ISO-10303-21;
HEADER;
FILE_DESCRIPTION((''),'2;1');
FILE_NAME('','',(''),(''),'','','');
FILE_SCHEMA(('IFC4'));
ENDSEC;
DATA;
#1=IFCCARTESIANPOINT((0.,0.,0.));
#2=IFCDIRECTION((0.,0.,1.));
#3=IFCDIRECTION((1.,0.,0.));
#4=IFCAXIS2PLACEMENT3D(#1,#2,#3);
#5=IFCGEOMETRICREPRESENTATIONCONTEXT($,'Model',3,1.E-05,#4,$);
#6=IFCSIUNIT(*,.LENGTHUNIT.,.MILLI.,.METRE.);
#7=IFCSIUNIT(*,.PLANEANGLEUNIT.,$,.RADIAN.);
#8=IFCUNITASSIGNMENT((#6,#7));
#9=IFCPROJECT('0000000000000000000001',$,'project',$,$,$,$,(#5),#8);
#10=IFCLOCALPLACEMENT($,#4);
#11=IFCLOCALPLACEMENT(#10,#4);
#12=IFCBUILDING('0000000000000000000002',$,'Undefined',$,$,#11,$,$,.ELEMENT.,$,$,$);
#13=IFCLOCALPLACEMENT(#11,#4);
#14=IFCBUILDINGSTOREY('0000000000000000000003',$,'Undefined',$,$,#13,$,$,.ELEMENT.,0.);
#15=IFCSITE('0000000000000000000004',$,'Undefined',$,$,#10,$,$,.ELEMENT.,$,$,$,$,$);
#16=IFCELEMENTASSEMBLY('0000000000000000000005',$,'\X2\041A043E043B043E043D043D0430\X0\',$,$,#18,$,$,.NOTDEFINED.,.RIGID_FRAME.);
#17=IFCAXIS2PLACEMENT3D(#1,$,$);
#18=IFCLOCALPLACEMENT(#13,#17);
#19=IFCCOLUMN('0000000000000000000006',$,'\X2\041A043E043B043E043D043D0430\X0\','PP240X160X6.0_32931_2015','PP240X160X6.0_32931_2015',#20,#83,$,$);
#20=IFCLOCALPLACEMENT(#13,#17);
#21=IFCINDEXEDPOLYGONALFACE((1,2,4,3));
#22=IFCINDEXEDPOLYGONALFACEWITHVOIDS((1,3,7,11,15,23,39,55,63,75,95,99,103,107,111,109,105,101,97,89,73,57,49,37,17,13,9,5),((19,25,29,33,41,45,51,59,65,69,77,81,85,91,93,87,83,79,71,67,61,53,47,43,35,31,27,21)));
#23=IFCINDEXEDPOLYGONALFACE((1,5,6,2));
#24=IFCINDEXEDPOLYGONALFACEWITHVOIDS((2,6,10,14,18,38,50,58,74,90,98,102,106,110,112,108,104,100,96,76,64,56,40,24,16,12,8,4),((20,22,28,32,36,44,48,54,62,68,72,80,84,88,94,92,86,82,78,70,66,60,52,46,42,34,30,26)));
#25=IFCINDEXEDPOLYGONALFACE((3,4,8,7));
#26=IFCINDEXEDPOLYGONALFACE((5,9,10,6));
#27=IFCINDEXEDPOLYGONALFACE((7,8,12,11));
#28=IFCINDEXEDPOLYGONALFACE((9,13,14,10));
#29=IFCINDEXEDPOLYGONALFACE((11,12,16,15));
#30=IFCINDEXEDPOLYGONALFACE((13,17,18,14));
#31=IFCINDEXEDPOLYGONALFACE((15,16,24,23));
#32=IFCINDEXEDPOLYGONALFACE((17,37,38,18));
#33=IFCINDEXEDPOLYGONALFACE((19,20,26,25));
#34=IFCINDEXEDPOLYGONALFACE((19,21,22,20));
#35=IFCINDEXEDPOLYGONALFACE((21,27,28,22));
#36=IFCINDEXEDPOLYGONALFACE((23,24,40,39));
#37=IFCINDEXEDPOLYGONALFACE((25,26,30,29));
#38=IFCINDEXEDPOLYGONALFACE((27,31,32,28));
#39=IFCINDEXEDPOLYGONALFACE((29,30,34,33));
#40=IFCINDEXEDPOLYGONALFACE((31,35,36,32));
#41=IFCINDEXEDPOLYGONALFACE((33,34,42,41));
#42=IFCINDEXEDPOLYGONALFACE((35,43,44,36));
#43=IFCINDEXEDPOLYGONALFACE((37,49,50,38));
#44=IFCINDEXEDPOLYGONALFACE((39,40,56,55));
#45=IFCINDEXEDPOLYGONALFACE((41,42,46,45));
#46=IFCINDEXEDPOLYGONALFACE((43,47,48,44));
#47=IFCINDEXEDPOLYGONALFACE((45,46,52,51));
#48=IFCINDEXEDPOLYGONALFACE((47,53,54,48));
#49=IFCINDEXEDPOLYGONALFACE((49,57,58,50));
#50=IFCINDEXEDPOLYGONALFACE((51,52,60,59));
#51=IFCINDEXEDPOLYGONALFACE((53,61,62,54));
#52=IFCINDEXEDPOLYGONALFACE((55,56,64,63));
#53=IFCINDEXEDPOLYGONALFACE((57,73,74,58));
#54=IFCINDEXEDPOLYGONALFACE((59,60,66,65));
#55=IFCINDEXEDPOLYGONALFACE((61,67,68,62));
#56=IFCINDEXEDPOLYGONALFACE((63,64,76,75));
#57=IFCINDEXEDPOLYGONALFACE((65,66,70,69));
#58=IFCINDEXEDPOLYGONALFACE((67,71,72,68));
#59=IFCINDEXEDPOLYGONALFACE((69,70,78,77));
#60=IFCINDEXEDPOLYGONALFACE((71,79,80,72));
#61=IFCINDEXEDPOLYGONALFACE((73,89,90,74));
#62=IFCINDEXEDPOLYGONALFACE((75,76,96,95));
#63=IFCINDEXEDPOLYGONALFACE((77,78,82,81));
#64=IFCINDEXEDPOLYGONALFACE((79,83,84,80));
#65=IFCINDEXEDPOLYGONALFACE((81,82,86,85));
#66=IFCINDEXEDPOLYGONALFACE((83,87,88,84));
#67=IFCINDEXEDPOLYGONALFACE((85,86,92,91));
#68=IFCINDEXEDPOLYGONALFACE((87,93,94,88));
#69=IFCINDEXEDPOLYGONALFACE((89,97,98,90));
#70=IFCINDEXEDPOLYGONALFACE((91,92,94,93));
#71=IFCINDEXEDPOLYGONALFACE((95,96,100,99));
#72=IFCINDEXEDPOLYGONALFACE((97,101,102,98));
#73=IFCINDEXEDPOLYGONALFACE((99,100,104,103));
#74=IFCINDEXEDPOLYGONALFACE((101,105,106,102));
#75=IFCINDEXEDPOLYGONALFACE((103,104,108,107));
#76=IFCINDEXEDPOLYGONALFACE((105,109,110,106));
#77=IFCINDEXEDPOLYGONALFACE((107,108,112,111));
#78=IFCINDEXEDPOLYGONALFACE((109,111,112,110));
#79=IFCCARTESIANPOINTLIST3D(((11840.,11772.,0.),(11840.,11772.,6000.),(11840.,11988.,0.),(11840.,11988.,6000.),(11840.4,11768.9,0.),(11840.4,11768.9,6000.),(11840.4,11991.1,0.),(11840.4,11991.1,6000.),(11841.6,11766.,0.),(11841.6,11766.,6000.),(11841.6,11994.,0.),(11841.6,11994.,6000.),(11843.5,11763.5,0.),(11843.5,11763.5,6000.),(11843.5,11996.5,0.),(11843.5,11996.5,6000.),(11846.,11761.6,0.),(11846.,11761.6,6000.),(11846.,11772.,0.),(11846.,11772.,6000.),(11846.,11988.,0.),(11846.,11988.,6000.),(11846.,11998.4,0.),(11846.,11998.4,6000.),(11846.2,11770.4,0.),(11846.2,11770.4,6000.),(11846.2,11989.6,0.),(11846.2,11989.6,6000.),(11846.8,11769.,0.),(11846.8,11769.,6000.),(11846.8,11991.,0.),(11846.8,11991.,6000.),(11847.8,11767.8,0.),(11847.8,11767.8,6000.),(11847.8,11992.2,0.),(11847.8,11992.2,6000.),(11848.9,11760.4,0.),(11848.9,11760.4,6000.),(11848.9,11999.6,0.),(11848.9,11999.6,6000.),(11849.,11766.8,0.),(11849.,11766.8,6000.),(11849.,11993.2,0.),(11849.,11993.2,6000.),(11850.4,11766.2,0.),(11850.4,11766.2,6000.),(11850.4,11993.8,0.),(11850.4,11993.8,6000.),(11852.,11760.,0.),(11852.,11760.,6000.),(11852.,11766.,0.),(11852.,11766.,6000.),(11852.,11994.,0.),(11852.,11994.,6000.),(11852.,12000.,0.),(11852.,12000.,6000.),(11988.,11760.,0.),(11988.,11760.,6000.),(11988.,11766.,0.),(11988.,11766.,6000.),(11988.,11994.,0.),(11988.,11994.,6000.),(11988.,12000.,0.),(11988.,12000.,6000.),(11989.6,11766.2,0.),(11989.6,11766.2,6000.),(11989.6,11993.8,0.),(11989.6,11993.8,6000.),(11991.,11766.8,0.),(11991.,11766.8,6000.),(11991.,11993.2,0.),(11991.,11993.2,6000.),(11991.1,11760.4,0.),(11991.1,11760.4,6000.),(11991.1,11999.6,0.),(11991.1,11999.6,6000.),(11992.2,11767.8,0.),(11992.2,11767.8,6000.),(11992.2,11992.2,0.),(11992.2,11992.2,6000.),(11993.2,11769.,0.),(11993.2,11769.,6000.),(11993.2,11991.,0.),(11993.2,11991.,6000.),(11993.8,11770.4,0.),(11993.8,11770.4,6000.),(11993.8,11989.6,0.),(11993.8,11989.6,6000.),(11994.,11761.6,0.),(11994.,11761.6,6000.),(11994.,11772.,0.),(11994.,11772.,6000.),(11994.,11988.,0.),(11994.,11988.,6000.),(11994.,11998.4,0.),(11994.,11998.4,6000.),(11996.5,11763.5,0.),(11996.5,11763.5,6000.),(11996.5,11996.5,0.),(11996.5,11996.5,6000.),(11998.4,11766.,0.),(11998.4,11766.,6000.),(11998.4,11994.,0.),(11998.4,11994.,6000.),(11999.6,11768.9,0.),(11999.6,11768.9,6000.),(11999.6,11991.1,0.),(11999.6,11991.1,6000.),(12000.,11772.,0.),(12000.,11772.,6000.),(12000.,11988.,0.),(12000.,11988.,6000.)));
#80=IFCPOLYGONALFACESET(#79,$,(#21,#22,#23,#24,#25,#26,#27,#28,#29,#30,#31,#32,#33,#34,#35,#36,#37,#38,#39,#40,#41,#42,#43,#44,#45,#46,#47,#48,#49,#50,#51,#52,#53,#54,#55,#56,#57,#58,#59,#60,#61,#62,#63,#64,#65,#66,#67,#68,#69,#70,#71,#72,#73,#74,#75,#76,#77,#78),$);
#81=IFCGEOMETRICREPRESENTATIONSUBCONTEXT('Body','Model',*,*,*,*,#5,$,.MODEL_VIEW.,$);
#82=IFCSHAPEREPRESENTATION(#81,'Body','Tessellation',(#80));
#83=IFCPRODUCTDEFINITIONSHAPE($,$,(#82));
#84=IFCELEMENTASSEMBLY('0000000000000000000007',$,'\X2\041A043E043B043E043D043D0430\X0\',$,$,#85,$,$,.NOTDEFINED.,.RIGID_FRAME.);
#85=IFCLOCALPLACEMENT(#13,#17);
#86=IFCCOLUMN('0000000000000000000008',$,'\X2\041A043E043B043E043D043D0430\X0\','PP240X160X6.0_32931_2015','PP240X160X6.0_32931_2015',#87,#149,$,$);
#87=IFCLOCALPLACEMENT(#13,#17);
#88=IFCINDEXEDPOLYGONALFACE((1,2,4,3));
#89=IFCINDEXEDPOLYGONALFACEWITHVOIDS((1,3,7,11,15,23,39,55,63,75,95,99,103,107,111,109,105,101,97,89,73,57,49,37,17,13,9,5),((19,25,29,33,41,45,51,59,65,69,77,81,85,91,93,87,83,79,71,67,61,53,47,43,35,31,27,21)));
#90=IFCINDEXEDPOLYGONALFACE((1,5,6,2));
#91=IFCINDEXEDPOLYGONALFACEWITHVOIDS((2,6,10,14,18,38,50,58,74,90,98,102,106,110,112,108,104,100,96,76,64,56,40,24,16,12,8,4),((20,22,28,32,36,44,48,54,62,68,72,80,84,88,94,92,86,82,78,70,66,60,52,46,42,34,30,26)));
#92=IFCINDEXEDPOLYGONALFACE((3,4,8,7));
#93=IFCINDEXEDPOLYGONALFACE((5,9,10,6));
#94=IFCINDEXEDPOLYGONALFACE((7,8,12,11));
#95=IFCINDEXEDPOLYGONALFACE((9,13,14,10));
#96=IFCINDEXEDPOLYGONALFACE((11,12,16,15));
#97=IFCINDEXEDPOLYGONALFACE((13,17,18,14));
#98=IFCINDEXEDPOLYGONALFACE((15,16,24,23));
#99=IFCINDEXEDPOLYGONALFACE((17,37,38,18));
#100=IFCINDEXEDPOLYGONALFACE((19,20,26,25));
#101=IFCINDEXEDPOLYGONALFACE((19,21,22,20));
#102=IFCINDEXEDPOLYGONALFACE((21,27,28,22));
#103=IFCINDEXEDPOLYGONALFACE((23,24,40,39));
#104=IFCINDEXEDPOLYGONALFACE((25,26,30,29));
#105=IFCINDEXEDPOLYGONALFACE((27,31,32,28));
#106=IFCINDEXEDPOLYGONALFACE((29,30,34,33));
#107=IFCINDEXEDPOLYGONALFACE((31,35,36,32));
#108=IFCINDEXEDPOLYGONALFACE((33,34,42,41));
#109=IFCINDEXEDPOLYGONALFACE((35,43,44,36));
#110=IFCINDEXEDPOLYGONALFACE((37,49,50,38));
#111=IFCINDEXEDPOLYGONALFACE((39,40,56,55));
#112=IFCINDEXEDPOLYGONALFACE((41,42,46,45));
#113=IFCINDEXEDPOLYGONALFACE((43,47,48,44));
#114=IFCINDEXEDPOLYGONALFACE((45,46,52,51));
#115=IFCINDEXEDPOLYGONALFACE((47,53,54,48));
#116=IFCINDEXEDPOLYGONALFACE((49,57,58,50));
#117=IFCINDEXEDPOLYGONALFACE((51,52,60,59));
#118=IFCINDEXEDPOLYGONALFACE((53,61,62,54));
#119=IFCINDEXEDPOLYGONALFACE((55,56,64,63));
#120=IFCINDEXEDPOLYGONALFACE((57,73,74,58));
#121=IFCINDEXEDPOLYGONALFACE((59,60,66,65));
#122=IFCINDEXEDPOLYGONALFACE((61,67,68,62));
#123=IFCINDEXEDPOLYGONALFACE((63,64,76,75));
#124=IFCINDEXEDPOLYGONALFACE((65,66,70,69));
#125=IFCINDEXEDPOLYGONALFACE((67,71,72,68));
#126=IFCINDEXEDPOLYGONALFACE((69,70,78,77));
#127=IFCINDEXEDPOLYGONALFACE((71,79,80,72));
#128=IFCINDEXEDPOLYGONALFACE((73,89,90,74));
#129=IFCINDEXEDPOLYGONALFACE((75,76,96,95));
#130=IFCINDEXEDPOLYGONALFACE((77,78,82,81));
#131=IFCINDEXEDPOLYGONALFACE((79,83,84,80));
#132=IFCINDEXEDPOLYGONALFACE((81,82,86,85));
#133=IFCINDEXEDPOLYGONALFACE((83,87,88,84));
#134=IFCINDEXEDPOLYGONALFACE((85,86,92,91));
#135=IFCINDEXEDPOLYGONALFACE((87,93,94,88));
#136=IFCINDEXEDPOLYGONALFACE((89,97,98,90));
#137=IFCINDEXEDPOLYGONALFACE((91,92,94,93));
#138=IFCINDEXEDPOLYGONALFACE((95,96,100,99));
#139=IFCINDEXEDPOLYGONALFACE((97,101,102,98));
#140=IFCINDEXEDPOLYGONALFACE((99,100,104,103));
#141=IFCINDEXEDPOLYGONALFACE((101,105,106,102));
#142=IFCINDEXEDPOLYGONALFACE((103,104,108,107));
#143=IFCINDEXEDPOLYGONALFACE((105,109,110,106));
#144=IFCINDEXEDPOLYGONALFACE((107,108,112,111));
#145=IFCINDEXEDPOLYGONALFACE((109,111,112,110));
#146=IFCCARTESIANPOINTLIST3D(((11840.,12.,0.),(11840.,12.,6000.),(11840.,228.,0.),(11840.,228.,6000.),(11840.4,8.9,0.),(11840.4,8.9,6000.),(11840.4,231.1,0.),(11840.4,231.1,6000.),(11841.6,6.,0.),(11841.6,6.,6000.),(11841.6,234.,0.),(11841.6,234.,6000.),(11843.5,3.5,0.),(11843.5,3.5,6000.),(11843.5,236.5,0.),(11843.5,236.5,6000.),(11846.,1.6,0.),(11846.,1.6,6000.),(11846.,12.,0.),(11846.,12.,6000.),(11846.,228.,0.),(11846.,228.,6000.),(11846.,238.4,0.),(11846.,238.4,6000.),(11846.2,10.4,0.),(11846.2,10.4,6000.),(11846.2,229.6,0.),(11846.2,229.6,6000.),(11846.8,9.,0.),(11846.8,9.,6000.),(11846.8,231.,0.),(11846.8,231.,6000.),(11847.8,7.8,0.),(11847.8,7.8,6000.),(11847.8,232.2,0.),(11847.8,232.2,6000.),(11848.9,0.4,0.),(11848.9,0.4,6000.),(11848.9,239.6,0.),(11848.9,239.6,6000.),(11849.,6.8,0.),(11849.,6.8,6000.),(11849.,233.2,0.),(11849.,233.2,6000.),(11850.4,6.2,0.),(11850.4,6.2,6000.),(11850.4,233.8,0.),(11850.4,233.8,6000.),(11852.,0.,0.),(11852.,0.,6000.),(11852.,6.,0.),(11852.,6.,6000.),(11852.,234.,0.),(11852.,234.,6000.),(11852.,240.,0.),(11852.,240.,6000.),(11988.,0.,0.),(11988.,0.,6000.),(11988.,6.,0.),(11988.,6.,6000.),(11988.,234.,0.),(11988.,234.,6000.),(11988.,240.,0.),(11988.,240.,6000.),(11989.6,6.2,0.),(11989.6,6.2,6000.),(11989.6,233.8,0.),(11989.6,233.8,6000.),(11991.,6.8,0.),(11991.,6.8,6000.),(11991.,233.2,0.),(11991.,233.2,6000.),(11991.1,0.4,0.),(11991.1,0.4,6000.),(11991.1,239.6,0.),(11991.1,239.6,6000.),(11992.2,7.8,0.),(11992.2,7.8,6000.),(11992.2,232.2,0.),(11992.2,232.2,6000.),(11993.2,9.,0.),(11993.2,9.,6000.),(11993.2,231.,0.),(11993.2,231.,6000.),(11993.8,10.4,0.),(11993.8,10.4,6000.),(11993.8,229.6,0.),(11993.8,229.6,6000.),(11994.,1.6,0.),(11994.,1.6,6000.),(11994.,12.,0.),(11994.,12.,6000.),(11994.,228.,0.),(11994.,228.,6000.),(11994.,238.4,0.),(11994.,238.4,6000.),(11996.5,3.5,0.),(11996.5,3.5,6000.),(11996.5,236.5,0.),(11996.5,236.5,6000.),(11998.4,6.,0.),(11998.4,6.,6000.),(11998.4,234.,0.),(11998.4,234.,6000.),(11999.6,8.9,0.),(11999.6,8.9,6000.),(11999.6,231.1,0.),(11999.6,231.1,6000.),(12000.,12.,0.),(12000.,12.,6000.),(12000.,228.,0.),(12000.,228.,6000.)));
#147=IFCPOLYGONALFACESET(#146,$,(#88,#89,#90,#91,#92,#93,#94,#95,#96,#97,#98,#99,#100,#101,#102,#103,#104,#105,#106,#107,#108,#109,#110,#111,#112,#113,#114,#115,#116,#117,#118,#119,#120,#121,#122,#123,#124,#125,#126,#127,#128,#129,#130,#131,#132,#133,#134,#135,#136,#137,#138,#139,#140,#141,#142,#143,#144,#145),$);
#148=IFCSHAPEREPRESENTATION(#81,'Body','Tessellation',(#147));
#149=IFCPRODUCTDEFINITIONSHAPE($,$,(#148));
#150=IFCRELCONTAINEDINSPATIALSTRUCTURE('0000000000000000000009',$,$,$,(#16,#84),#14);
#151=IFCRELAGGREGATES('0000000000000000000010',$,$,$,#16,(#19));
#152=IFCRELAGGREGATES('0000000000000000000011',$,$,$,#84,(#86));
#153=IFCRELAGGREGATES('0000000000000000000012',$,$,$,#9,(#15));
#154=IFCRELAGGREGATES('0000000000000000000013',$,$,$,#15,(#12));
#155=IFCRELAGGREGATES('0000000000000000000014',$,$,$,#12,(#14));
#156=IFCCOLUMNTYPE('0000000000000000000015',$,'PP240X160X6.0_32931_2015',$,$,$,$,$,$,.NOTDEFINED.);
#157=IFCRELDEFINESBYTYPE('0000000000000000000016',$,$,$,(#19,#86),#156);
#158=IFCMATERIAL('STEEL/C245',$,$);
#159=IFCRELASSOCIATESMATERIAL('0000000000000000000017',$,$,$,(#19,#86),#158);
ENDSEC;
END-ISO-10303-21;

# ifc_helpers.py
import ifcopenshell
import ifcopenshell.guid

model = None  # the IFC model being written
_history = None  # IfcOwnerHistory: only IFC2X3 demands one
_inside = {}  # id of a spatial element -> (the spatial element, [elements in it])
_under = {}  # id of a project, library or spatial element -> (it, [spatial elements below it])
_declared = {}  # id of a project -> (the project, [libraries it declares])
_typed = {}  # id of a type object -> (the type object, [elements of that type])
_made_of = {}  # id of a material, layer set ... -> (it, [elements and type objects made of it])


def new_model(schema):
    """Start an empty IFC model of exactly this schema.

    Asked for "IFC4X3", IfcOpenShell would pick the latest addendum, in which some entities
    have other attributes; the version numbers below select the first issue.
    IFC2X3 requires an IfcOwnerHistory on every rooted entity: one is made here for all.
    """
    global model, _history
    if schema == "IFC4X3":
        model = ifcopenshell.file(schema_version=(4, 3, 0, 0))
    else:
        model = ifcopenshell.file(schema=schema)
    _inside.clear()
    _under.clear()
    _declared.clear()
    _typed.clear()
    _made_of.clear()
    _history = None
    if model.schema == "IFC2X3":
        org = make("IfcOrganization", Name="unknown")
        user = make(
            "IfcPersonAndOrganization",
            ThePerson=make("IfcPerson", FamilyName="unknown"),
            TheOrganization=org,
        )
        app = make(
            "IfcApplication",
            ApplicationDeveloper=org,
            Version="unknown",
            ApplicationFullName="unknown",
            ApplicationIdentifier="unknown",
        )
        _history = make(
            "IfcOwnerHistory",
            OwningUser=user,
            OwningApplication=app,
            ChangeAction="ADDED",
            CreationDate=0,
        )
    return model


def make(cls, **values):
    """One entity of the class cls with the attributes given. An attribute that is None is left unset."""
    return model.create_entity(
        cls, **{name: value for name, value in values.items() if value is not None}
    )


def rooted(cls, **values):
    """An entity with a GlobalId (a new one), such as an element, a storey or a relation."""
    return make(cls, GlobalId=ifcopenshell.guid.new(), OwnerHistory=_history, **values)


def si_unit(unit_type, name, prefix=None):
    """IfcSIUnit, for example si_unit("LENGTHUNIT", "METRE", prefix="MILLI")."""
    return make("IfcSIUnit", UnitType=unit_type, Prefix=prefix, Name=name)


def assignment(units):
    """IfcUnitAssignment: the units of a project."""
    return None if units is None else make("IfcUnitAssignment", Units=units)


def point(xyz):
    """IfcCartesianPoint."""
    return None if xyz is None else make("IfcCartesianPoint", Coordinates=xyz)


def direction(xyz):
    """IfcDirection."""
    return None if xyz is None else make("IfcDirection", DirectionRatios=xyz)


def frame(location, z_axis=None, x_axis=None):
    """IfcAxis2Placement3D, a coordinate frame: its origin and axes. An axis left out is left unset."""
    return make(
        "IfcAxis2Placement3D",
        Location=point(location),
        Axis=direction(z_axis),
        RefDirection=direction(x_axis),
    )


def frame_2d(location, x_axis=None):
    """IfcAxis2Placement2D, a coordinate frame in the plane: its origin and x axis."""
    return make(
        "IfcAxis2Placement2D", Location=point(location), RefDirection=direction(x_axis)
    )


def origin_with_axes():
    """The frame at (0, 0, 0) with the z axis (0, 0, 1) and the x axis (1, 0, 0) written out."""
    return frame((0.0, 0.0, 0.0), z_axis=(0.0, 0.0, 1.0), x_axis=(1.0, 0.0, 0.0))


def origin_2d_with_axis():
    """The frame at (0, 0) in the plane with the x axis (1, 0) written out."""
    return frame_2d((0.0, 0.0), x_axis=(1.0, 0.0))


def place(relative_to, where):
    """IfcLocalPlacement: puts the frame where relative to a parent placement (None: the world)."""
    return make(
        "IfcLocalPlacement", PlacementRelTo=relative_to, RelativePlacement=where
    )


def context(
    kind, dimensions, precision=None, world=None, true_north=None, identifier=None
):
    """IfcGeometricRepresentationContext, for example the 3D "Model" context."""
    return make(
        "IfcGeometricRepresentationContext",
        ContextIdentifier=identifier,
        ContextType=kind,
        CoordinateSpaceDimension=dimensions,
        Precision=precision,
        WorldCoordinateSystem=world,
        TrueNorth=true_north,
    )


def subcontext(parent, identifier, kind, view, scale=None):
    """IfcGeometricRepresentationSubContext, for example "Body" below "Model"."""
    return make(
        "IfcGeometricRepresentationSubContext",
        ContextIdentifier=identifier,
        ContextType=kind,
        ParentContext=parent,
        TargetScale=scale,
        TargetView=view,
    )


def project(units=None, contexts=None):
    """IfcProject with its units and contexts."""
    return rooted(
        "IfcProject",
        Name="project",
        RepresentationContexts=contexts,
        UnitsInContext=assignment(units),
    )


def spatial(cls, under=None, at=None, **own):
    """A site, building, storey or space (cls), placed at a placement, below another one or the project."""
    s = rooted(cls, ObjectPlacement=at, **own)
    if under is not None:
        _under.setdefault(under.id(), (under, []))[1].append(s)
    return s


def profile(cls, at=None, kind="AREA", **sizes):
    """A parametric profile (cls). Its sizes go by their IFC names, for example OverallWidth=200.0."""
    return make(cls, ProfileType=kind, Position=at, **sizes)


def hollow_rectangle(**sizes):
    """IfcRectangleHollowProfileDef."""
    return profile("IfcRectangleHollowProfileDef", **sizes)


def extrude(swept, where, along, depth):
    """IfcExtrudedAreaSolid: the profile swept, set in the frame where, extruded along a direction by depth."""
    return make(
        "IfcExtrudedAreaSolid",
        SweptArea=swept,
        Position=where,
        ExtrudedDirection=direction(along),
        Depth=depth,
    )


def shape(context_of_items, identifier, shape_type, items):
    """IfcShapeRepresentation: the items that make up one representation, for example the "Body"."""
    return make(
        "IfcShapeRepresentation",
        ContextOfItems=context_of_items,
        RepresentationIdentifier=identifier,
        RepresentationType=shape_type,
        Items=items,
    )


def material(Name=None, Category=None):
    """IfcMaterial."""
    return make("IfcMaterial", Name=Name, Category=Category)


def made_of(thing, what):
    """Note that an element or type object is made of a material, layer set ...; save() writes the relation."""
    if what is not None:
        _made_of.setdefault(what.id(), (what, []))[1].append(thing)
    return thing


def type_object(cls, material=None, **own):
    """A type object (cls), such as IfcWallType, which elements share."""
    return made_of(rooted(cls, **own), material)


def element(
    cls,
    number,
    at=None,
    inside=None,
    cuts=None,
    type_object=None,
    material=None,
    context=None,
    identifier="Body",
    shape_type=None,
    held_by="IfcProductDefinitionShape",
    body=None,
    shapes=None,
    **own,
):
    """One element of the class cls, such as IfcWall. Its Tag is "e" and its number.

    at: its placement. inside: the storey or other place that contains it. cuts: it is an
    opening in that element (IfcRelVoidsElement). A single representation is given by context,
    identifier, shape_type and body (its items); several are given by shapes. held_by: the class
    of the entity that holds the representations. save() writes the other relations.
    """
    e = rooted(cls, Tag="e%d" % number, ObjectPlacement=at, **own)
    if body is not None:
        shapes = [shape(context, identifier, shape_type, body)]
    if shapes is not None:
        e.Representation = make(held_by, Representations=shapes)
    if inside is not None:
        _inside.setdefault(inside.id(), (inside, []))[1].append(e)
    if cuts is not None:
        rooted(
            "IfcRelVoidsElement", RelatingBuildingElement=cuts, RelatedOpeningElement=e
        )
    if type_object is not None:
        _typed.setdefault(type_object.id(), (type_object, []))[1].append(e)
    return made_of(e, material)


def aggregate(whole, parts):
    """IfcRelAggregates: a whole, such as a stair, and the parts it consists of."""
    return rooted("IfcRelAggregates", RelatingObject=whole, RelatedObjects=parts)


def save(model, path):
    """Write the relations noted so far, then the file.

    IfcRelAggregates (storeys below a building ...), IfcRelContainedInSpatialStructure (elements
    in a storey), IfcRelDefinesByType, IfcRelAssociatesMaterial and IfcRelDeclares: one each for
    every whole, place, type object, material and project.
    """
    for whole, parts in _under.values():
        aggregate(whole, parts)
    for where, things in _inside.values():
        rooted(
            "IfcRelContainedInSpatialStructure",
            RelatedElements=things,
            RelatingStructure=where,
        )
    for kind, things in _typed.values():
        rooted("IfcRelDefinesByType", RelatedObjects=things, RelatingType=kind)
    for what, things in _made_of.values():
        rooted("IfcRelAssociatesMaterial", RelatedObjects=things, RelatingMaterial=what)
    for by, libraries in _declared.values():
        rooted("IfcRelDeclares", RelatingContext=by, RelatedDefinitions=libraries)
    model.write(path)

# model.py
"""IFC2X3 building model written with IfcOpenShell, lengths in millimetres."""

from ifc_helpers import new_model, si_unit, frame, origin_with_axes, origin_2d_with_axis, place, context, subcontext, project, spatial, hollow_rectangle, extrude, material, type_object, element, aggregate, save


model = new_model("IFC2X3")

# Units and contexts
model_context = context("Model", 3, precision=1e-05, world=origin_with_axes())
body_context = subcontext(model_context, "Body", "Model", "MODEL_VIEW")
ifc_project = project(units=[si_unit("LENGTHUNIT", "METRE", prefix="MILLI"), si_unit("PLANEANGLEUNIT", "RADIAN")], contexts=[model_context])

# Site, building, storey
site_placement = place(None, origin_with_axes())
site = spatial("IfcSite", under=ifc_project, at=site_placement, Name="Undefined", CompositionType="ELEMENT")
building_placement = place(site_placement, origin_with_axes())
building = spatial("IfcBuilding", under=site, at=building_placement, Name="Undefined", CompositionType="ELEMENT")
storey_placement = place(building_placement, origin_with_axes())
storey = spatial("IfcBuildingStorey", under=building, at=storey_placement, Name="Undefined", CompositionType="ELEMENT", Elevation=0.0)

# Element assemblies, columns
assembly_1_placement = place(storey_placement, origin_with_axes())
assembly_1 = element("IfcElementAssembly", 1, at=assembly_1_placement, inside=storey, Name="Колонна", AssemblyPlace="NOTDEFINED", PredefinedType="RIGID_FRAME")
ifc_material = material(Name="STEEL/C245")
column_type = type_object("IfcColumnType", Name="PP240X160X6.0_32931_2015", PredefinedType="NOTDEFINED")
column_1_placement = place(assembly_1_placement, frame((11920.0, 11880.0, 0.0), z_axis=(0.0, 0.0, 1.0), x_axis=(0.0, -1.0, 0.0)))
column_1 = element("IfcColumn", 2, at=column_1_placement, type_object=column_type, material=ifc_material, Name="Колонна", Description="PP240X160X6.0_32931_2015", ObjectType="PP240X160X6.0_32931_2015", context=body_context, shape_type="SweptSolid", body=[
    extrude(hollow_rectangle(XDim=160.0, YDim=240.0, WallThickness=6.0, InnerFilletRadius=6.0, OuterFilletRadius=12.0, at=origin_2d_with_axis()), frame((0.0, 0.0, 6000.0), z_axis=(0.0, 0.0, -1.0), x_axis=(0.0, 1.0, 0.0)), (0.0, 0.0, 1.0), 6000.0),
])
aggregate(assembly_1, [column_1])
assembly_2_placement = place(storey_placement, origin_with_axes())
assembly_2 = element("IfcElementAssembly", 3, at=assembly_2_placement, inside=storey, Name="Колонна", AssemblyPlace="NOTDEFINED", PredefinedType="RIGID_FRAME")
column_2_placement = place(assembly_2_placement, frame((11920.0, 120.0, 0.0), z_axis=(0.0, 0.0, 1.0), x_axis=(0.0, 1.0, 0.0)))
column_2 = element("IfcColumn", 4, at=column_2_placement, type_object=column_type, material=ifc_material, Name="Колонна", Description="PP240X160X6.0_32931_2015", ObjectType="PP240X160X6.0_32931_2015", context=body_context, shape_type="SweptSolid", body=[
    extrude(hollow_rectangle(XDim=160.0, YDim=240.0, WallThickness=6.0, InnerFilletRadius=6.0, OuterFilletRadius=12.0, at=origin_2d_with_axis()), frame((0.0, 0.0, 6000.0), z_axis=(0.0, 0.0, -1.0), x_axis=(0.0, 1.0, 0.0)), (0.0, 0.0, 1.0), 6000.0),
])
aggregate(assembly_2, [column_2])

save(model, "model.ifc")
